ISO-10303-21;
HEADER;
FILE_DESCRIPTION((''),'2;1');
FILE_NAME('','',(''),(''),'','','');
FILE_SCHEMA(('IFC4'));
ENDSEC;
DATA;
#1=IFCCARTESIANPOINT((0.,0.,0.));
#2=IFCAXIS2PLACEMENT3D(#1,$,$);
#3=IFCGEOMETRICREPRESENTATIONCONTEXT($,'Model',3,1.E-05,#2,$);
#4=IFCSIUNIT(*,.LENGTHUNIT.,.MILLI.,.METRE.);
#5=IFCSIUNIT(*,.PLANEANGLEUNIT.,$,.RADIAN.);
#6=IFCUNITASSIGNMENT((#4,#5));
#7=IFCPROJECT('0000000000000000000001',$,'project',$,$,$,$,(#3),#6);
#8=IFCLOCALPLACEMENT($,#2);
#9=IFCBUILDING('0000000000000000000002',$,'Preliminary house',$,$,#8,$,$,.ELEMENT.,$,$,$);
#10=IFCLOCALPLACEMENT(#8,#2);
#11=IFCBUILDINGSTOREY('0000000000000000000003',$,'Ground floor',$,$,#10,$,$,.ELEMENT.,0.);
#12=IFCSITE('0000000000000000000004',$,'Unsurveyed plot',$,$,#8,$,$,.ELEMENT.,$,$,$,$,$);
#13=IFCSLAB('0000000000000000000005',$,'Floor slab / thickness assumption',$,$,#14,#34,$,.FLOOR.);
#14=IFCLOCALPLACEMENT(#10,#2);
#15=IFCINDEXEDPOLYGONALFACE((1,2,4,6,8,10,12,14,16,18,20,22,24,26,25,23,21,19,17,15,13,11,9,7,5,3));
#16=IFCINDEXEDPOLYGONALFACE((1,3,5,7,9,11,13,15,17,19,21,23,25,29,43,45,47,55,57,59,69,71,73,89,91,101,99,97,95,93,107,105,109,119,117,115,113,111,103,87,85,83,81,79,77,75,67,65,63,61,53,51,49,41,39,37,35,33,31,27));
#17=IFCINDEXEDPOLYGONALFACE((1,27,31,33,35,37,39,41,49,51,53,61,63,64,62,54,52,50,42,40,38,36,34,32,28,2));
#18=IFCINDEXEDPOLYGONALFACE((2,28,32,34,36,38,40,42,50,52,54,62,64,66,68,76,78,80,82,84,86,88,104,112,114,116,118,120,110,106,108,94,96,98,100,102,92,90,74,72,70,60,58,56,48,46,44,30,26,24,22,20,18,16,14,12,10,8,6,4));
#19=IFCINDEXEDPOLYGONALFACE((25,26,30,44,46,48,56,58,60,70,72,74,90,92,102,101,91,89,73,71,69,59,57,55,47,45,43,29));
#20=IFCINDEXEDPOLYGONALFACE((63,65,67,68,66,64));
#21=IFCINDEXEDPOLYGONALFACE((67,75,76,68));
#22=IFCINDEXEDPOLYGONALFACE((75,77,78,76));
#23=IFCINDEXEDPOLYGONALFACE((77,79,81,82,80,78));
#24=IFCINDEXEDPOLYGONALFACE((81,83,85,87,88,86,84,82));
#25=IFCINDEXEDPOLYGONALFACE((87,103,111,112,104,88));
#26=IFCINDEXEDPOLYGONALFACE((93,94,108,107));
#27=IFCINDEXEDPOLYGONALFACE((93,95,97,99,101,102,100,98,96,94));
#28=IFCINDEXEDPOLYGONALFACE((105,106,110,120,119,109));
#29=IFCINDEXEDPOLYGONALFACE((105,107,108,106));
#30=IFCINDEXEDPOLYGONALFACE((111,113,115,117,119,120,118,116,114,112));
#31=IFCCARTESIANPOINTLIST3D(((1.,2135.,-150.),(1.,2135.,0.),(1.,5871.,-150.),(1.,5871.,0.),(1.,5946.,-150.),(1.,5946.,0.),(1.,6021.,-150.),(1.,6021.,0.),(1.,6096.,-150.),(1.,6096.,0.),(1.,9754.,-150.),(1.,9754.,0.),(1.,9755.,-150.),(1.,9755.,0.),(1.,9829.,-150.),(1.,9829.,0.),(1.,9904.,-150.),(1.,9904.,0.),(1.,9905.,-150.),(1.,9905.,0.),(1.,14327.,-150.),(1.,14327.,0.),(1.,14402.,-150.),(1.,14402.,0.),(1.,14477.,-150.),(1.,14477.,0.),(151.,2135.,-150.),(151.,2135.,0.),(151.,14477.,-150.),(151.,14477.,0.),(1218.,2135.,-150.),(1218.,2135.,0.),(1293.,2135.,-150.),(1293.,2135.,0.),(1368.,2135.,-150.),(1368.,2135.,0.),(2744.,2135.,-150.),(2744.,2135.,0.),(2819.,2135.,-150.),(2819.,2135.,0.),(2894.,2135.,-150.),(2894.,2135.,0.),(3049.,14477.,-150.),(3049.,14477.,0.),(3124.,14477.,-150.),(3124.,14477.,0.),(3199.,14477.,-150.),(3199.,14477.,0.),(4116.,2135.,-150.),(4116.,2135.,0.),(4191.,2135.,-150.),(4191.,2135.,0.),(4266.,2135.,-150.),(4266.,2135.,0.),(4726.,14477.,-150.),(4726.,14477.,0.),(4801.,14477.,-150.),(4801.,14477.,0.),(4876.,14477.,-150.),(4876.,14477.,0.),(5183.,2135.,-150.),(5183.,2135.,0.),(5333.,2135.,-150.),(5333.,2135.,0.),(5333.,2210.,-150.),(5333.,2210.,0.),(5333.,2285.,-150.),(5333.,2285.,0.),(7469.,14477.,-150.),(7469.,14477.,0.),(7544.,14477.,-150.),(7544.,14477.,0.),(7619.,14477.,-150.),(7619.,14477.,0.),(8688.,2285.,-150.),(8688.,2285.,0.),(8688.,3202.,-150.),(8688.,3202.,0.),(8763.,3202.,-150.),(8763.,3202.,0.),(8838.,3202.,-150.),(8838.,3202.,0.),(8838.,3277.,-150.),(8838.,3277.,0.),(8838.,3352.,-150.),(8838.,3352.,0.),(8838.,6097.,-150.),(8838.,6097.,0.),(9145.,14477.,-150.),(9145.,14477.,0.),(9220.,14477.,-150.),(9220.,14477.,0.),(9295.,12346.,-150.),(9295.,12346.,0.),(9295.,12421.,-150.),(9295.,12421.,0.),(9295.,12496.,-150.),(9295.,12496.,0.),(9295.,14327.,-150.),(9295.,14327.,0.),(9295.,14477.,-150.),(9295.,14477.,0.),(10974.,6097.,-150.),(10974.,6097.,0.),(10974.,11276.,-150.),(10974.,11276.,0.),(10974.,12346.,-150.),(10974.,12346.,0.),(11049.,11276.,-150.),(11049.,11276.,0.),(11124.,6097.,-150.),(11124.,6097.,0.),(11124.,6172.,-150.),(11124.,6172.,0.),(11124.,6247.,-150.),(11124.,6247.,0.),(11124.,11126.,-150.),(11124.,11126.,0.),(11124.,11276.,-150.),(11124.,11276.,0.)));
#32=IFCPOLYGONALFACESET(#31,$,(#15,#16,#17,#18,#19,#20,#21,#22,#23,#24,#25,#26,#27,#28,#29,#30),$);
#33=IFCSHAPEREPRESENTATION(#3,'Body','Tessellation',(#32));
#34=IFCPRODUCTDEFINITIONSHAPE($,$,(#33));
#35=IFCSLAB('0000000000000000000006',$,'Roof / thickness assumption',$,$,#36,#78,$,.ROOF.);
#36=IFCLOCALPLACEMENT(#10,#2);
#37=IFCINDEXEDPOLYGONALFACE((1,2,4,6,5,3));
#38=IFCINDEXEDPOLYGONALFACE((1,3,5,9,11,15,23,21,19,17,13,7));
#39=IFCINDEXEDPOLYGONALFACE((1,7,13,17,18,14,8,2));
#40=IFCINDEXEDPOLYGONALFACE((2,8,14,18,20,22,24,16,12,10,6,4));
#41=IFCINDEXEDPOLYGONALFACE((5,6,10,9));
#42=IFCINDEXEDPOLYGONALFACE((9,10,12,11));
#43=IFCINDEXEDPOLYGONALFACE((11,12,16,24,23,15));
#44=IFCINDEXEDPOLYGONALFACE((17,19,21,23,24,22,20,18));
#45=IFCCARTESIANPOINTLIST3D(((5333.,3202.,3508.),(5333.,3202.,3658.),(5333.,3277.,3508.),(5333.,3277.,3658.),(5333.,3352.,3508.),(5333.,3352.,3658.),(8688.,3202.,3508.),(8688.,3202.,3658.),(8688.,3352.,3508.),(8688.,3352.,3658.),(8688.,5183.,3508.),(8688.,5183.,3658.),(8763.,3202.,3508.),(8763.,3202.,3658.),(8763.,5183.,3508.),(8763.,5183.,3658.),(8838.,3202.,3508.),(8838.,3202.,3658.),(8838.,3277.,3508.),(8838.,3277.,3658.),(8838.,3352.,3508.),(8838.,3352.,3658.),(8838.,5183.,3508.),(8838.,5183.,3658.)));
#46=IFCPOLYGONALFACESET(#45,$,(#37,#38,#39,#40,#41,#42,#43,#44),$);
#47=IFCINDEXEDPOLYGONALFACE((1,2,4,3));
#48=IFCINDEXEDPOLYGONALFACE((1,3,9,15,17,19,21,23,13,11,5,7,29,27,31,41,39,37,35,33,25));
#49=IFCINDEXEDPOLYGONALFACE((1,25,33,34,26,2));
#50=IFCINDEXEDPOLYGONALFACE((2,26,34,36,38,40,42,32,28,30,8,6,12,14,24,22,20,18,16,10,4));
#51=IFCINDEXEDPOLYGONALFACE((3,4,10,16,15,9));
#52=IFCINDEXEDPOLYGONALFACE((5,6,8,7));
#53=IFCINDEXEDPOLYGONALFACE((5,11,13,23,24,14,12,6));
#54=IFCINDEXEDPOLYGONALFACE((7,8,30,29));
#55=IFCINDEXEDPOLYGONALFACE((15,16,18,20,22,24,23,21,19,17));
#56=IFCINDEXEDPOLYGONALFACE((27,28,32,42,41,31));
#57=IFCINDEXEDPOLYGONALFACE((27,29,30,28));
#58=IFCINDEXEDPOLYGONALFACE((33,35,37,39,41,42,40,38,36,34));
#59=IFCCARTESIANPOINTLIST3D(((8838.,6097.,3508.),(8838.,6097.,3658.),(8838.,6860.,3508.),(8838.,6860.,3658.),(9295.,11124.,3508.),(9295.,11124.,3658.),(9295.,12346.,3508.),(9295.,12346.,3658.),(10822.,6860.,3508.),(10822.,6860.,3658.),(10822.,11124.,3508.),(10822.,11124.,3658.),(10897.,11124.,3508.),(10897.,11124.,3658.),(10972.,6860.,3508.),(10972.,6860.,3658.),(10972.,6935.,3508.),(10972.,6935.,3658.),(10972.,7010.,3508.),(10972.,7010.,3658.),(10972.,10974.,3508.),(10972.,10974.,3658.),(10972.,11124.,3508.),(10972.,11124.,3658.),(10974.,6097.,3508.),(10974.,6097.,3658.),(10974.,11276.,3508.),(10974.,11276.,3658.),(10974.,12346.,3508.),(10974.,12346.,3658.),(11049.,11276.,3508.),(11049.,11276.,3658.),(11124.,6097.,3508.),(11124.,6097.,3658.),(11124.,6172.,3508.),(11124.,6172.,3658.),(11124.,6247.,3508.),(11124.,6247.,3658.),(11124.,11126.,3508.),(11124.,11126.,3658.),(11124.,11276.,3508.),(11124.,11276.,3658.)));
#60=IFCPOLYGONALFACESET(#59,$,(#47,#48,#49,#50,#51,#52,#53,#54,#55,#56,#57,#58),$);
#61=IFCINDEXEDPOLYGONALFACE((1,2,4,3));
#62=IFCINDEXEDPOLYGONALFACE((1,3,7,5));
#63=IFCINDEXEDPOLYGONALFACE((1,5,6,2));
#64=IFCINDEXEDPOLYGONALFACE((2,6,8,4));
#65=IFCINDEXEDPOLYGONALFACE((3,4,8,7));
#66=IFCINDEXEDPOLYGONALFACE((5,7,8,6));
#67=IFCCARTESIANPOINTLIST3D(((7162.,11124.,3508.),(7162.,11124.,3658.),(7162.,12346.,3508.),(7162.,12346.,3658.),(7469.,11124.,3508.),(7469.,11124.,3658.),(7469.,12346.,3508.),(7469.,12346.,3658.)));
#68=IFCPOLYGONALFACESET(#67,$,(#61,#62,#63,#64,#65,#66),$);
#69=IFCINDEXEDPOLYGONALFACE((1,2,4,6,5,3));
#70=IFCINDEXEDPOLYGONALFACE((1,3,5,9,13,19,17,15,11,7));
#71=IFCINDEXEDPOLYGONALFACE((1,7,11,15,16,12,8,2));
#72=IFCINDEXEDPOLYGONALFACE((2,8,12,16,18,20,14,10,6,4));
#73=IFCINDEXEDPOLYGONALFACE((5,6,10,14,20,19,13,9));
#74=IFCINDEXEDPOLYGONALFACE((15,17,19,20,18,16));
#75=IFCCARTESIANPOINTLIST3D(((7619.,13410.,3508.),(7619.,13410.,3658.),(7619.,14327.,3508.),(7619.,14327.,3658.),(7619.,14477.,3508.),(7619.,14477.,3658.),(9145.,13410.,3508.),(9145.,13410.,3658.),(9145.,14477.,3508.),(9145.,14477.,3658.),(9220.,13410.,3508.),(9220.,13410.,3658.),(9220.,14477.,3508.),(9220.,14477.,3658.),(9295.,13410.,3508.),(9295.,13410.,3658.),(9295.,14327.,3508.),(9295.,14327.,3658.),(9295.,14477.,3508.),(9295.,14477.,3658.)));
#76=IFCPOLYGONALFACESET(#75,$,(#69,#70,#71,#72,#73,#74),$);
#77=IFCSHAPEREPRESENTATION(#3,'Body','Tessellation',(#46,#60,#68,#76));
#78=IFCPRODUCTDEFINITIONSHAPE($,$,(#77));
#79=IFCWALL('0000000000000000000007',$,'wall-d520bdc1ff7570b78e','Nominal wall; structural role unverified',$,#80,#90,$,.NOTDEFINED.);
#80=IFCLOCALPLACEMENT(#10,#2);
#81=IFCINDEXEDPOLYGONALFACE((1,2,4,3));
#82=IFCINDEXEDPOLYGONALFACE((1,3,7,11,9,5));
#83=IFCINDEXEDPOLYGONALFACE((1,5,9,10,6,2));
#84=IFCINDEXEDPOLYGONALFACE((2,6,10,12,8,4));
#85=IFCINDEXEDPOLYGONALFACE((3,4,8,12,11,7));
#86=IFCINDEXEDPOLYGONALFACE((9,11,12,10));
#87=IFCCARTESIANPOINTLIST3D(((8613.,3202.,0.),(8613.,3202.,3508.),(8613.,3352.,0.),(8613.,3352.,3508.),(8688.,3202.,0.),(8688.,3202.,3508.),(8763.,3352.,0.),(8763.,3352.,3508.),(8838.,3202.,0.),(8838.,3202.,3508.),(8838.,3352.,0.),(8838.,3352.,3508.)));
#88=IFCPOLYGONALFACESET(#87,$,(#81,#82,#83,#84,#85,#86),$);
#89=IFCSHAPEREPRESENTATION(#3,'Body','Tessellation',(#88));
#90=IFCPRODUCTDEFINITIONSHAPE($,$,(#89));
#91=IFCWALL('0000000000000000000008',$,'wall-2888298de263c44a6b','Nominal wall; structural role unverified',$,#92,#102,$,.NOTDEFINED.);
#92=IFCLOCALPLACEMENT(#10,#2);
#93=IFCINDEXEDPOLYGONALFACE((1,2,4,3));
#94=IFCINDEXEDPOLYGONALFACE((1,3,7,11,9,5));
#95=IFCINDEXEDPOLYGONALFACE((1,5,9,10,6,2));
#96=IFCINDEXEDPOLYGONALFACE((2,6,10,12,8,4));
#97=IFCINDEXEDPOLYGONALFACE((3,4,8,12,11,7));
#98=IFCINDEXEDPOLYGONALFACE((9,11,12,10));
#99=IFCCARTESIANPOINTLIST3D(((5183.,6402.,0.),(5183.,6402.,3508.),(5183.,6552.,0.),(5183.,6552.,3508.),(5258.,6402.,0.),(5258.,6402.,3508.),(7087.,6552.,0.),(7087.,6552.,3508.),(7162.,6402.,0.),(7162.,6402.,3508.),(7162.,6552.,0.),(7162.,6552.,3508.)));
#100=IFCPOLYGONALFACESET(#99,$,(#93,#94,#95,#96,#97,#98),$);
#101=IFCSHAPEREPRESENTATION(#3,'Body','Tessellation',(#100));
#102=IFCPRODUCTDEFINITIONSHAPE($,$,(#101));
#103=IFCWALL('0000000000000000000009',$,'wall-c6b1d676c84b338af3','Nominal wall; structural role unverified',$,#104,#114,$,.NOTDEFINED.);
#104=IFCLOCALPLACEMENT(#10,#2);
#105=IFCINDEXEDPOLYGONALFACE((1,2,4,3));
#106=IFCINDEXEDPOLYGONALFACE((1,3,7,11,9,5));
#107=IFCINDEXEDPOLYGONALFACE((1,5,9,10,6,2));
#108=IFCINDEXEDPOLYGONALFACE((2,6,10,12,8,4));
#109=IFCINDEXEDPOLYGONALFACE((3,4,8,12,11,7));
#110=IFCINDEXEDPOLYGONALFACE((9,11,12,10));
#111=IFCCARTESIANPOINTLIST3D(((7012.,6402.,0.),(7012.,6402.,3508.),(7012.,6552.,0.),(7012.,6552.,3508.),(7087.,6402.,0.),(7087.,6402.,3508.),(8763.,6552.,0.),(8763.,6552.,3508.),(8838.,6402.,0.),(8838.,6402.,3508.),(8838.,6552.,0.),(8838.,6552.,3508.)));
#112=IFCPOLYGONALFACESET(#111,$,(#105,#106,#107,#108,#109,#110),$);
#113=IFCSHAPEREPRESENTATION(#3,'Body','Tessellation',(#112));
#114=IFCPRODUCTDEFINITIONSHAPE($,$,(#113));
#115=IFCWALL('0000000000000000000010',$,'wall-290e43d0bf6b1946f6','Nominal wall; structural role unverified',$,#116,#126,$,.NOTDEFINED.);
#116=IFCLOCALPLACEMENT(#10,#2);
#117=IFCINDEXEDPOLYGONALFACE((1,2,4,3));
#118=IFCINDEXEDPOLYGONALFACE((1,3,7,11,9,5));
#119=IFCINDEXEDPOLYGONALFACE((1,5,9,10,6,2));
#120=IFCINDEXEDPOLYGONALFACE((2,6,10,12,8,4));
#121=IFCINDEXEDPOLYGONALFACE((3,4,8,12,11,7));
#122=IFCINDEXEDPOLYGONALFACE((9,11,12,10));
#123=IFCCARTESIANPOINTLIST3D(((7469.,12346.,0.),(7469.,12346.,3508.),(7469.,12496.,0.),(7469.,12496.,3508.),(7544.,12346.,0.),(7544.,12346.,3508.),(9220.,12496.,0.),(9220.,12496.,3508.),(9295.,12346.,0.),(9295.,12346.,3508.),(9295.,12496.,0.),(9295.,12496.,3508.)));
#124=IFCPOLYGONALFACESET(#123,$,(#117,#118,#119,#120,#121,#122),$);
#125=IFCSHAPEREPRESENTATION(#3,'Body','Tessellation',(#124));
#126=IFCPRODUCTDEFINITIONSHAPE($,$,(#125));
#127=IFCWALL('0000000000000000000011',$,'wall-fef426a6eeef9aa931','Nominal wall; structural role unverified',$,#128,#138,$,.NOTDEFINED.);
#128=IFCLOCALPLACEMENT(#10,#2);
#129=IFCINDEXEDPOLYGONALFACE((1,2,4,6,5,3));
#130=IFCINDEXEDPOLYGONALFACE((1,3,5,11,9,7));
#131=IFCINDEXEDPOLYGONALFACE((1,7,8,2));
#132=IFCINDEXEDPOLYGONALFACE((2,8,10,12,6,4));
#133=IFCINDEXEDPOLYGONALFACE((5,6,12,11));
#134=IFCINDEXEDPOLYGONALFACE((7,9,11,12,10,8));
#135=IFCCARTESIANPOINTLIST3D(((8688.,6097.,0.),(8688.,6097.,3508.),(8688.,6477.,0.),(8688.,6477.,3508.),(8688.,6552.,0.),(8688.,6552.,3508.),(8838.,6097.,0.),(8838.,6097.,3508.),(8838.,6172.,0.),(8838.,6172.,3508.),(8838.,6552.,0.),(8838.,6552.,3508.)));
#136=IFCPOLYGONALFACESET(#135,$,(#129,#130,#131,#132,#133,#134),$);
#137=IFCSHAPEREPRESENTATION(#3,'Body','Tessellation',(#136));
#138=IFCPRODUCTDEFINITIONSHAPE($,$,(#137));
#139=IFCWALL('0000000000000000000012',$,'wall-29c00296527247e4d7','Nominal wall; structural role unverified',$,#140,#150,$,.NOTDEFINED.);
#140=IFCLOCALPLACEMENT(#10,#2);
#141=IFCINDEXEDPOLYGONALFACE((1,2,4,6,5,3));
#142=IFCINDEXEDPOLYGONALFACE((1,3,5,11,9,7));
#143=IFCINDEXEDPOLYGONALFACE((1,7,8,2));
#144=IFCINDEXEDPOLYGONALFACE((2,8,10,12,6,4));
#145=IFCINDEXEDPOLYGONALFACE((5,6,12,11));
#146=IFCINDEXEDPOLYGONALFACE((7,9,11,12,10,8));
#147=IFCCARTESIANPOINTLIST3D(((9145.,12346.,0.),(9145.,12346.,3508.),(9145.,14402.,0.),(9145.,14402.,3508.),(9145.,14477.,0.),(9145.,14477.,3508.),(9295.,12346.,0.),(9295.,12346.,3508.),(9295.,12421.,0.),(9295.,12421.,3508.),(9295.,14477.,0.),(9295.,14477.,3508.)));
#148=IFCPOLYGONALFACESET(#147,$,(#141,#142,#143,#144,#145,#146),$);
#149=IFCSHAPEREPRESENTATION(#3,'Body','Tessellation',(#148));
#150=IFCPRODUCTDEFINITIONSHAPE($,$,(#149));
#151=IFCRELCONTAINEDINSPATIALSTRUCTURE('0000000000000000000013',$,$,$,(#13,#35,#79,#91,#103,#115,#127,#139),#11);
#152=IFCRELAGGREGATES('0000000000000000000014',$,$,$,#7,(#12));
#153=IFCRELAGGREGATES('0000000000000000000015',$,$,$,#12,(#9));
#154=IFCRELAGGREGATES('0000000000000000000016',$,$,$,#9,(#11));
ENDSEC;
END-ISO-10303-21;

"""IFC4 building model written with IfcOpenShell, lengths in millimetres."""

from ifc_helpers import new_model, si_unit, frame, origin, place, context, project, spatial, polyline, outline, extrude, element, save


model = new_model("IFC4")

# Units and contexts
model_context = context("Model", 3, precision=1e-05, world=origin())
ifc_project = project(units=[si_unit("LENGTHUNIT", "METRE", prefix="MILLI"), si_unit("PLANEANGLEUNIT", "RADIAN")], contexts=[model_context])

# Site, building, storey
placement_1 = place(None, origin())
site = spatial("IfcSite", under=ifc_project, at=placement_1, Name="Unsurveyed plot", CompositionType="ELEMENT")
building = spatial("IfcBuilding", under=site, at=placement_1, Name="Preliminary house", CompositionType="ELEMENT")
placement_2 = place(placement_1, origin())
storey = spatial("IfcBuildingStorey", under=building, at=placement_2, Name="Ground floor", CompositionType="ELEMENT", Elevation=0.0)

# Slabs
element("IfcSlab", 1, at=placement_2, inside=storey, Name="Floor slab / thickness assumption", PredefinedType="FLOOR", context=model_context, shape_type="SweptSolid", body=[
    extrude(outline(polyline([(1368.0, 2135.0), (1293.0, 2135.0), (1218.0, 2135.0), (151.0, 2135.0), (1.0, 2135.0), (1.0, 5871.0), (1.0, 5946.0), (1.0, 6021.0), (1.0, 6096.0), (1.0, 9754.0), (1.0, 9755.0), (1.0, 9829.0), (1.0, 9904.0), (1.0, 9905.0), (1.0, 14327.0), (1.0, 14402.0), (1.0, 14477.0), (151.0, 14477.0), (3049.0, 14477.0), (3124.0, 14477.0), (3199.0, 14477.0), (4726.0, 14477.0), (4801.0, 14477.0), (4876.0, 14477.0), (7469.0, 14477.0), (7544.0, 14477.0), (7619.0, 14477.0), (9145.0, 14477.0), (9220.0, 14477.0), (9295.0, 14477.0), (9295.0, 14327.0), (9295.0, 12496.0), (9295.0, 12421.0), (9295.0, 12346.0), (10974.0, 12346.0), (10974.0, 11276.0), (11049.0, 11276.0), (11124.0, 11276.0), (11124.0, 11126.0), (11124.0, 6247.0), (11124.0, 6172.0), (11124.0, 6097.0), (10974.0, 6097.0), (8838.0, 6097.0), (8838.0, 3352.0), (8838.0, 3277.0), (8838.0, 3202.0), (8763.0, 3202.0), (8688.0, 3202.0), (8688.0, 2285.0), (5333.0, 2285.0), (5333.0, 2210.0), (5333.0, 2135.0), (5183.0, 2135.0), (4266.0, 2135.0), (4191.0, 2135.0), (4116.0, 2135.0), (2894.0, 2135.0), (2819.0, 2135.0), (2744.0, 2135.0), (1368.0, 2135.0)])), frame((0.0, 0.0, -150.0)), (0.0, 0.0, 1.0), 150.0),
])
element("IfcSlab", 2, at=placement_2, inside=storey, Name="Roof / thickness assumption", PredefinedType="ROOF", context=model_context, shape_type="SweptSolid", body=[
    extrude(outline(polyline([(8838.0, 3202.0), (8763.0, 3202.0), (8688.0, 3202.0), (5333.0, 3202.0), (5333.0, 3277.0), (5333.0, 3352.0), (8688.0, 3352.0), (8688.0, 5183.0), (8763.0, 5183.0), (8838.0, 5183.0), (8838.0, 3352.0), (8838.0, 3277.0), (8838.0, 3202.0)])), frame((0.0, 0.0, 3508.0)), (0.0, 0.0, 1.0), 150.0),
    extrude(outline(polyline([(11049.0, 11276.0), (11124.0, 11276.0), (11124.0, 11126.0), (11124.0, 6247.0), (11124.0, 6172.0), (11124.0, 6097.0), (10974.0, 6097.0), (8838.0, 6097.0), (8838.0, 6860.0), (10822.0, 6860.0), (10972.0, 6860.0), (10972.0, 6935.0), (10972.0, 7010.0), (10972.0, 10974.0), (10972.0, 11124.0), (10897.0, 11124.0), (10822.0, 11124.0), (9295.0, 11124.0), (9295.0, 12346.0), (10974.0, 12346.0), (10974.0, 11276.0), (11049.0, 11276.0)])), frame((0.0, 0.0, 3508.0)), (0.0, 0.0, 1.0), 150.0),
    extrude(outline(polyline([(7162.0, 11124.0), (7162.0, 12346.0), (7469.0, 12346.0), (7469.0, 11124.0), (7162.0, 11124.0)])), frame((0.0, 0.0, 3508.0)), (0.0, 0.0, 1.0), 150.0),
    extrude(outline(polyline([(9295.0, 14477.0), (9295.0, 14327.0), (9295.0, 13410.0), (9220.0, 13410.0), (9145.0, 13410.0), (7619.0, 13410.0), (7619.0, 14327.0), (7619.0, 14477.0), (9145.0, 14477.0), (9220.0, 14477.0), (9295.0, 14477.0)])), frame((0.0, 0.0, 3508.0)), (0.0, 0.0, 1.0), 150.0),
])

# Walls
element("IfcWall", 3, at=placement_2, inside=storey, Name="wall-d520bdc1ff7570b78e", Description="Nominal wall; structural role unverified", PredefinedType="NOTDEFINED", context=model_context, shape_type="SweptSolid", body=[
    extrude(outline(polyline([(8763.0, 3352.0), (8838.0, 3352.0), (8838.0, 3202.0), (8688.0, 3202.0), (8613.0, 3202.0), (8613.0, 3352.0), (8763.0, 3352.0)])), origin(), (0.0, 0.0, 1.0), 3508.0),
])
element("IfcWall", 4, at=placement_2, inside=storey, Name="wall-2888298de263c44a6b", Description="Nominal wall; structural role unverified", PredefinedType="NOTDEFINED", context=model_context, shape_type="SweptSolid", body=[
    extrude(outline(polyline([(7087.0, 6552.0), (7162.0, 6552.0), (7162.0, 6402.0), (5258.0, 6402.0), (5183.0, 6402.0), (5183.0, 6552.0), (7087.0, 6552.0)])), origin(), (0.0, 0.0, 1.0), 3508.0),
])

# Wall
element("IfcWall", 5, at=placement_2, inside=storey, Name="wall-c6b1d676c84b338af3", Description="Nominal wall; structural role unverified", PredefinedType="NOTDEFINED", context=model_context, shape_type="SweptSolid", body=[
    extrude(outline(polyline([(8763.0, 6552.0), (8838.0, 6552.0), (8838.0, 6402.0), (7087.0, 6402.0), (7012.0, 6402.0), (7012.0, 6552.0), (8763.0, 6552.0)])), origin(), (0.0, 0.0, 1.0), 3508.0),
])

# Wall
element("IfcWall", 6, at=placement_2, inside=storey, Name="wall-290e43d0bf6b1946f6", Description="Nominal wall; structural role unverified", PredefinedType="NOTDEFINED", context=model_context, shape_type="SweptSolid", body=[
    extrude(outline(polyline([(9220.0, 12496.0), (9295.0, 12496.0), (9295.0, 12346.0), (7544.0, 12346.0), (7469.0, 12346.0), (7469.0, 12496.0), (9220.0, 12496.0)])), origin(), (0.0, 0.0, 1.0), 3508.0),
])

# Wall
element("IfcWall", 7, at=placement_2, inside=storey, Name="wall-fef426a6eeef9aa931", Description="Nominal wall; structural role unverified", PredefinedType="NOTDEFINED", context=model_context, shape_type="SweptSolid", body=[
    extrude(outline(polyline([(8688.0, 6477.0), (8688.0, 6552.0), (8838.0, 6552.0), (8838.0, 6172.0), (8838.0, 6097.0), (8688.0, 6097.0), (8688.0, 6477.0)])), origin(), (0.0, 0.0, 1.0), 3508.0),
])

# Wall
element("IfcWall", 8, at=placement_2, inside=storey, Name="wall-29c00296527247e4d7", Description="Nominal wall; structural role unverified", PredefinedType="NOTDEFINED", context=model_context, shape_type="SweptSolid", body=[
    extrude(outline(polyline([(9145.0, 14402.0), (9145.0, 14477.0), (9295.0, 14477.0), (9295.0, 12421.0), (9295.0, 12346.0), (9145.0, 12346.0), (9145.0, 14402.0)])), origin(), (0.0, 0.0, 1.0), 3508.0),
])

save(model, "model.ifc")
